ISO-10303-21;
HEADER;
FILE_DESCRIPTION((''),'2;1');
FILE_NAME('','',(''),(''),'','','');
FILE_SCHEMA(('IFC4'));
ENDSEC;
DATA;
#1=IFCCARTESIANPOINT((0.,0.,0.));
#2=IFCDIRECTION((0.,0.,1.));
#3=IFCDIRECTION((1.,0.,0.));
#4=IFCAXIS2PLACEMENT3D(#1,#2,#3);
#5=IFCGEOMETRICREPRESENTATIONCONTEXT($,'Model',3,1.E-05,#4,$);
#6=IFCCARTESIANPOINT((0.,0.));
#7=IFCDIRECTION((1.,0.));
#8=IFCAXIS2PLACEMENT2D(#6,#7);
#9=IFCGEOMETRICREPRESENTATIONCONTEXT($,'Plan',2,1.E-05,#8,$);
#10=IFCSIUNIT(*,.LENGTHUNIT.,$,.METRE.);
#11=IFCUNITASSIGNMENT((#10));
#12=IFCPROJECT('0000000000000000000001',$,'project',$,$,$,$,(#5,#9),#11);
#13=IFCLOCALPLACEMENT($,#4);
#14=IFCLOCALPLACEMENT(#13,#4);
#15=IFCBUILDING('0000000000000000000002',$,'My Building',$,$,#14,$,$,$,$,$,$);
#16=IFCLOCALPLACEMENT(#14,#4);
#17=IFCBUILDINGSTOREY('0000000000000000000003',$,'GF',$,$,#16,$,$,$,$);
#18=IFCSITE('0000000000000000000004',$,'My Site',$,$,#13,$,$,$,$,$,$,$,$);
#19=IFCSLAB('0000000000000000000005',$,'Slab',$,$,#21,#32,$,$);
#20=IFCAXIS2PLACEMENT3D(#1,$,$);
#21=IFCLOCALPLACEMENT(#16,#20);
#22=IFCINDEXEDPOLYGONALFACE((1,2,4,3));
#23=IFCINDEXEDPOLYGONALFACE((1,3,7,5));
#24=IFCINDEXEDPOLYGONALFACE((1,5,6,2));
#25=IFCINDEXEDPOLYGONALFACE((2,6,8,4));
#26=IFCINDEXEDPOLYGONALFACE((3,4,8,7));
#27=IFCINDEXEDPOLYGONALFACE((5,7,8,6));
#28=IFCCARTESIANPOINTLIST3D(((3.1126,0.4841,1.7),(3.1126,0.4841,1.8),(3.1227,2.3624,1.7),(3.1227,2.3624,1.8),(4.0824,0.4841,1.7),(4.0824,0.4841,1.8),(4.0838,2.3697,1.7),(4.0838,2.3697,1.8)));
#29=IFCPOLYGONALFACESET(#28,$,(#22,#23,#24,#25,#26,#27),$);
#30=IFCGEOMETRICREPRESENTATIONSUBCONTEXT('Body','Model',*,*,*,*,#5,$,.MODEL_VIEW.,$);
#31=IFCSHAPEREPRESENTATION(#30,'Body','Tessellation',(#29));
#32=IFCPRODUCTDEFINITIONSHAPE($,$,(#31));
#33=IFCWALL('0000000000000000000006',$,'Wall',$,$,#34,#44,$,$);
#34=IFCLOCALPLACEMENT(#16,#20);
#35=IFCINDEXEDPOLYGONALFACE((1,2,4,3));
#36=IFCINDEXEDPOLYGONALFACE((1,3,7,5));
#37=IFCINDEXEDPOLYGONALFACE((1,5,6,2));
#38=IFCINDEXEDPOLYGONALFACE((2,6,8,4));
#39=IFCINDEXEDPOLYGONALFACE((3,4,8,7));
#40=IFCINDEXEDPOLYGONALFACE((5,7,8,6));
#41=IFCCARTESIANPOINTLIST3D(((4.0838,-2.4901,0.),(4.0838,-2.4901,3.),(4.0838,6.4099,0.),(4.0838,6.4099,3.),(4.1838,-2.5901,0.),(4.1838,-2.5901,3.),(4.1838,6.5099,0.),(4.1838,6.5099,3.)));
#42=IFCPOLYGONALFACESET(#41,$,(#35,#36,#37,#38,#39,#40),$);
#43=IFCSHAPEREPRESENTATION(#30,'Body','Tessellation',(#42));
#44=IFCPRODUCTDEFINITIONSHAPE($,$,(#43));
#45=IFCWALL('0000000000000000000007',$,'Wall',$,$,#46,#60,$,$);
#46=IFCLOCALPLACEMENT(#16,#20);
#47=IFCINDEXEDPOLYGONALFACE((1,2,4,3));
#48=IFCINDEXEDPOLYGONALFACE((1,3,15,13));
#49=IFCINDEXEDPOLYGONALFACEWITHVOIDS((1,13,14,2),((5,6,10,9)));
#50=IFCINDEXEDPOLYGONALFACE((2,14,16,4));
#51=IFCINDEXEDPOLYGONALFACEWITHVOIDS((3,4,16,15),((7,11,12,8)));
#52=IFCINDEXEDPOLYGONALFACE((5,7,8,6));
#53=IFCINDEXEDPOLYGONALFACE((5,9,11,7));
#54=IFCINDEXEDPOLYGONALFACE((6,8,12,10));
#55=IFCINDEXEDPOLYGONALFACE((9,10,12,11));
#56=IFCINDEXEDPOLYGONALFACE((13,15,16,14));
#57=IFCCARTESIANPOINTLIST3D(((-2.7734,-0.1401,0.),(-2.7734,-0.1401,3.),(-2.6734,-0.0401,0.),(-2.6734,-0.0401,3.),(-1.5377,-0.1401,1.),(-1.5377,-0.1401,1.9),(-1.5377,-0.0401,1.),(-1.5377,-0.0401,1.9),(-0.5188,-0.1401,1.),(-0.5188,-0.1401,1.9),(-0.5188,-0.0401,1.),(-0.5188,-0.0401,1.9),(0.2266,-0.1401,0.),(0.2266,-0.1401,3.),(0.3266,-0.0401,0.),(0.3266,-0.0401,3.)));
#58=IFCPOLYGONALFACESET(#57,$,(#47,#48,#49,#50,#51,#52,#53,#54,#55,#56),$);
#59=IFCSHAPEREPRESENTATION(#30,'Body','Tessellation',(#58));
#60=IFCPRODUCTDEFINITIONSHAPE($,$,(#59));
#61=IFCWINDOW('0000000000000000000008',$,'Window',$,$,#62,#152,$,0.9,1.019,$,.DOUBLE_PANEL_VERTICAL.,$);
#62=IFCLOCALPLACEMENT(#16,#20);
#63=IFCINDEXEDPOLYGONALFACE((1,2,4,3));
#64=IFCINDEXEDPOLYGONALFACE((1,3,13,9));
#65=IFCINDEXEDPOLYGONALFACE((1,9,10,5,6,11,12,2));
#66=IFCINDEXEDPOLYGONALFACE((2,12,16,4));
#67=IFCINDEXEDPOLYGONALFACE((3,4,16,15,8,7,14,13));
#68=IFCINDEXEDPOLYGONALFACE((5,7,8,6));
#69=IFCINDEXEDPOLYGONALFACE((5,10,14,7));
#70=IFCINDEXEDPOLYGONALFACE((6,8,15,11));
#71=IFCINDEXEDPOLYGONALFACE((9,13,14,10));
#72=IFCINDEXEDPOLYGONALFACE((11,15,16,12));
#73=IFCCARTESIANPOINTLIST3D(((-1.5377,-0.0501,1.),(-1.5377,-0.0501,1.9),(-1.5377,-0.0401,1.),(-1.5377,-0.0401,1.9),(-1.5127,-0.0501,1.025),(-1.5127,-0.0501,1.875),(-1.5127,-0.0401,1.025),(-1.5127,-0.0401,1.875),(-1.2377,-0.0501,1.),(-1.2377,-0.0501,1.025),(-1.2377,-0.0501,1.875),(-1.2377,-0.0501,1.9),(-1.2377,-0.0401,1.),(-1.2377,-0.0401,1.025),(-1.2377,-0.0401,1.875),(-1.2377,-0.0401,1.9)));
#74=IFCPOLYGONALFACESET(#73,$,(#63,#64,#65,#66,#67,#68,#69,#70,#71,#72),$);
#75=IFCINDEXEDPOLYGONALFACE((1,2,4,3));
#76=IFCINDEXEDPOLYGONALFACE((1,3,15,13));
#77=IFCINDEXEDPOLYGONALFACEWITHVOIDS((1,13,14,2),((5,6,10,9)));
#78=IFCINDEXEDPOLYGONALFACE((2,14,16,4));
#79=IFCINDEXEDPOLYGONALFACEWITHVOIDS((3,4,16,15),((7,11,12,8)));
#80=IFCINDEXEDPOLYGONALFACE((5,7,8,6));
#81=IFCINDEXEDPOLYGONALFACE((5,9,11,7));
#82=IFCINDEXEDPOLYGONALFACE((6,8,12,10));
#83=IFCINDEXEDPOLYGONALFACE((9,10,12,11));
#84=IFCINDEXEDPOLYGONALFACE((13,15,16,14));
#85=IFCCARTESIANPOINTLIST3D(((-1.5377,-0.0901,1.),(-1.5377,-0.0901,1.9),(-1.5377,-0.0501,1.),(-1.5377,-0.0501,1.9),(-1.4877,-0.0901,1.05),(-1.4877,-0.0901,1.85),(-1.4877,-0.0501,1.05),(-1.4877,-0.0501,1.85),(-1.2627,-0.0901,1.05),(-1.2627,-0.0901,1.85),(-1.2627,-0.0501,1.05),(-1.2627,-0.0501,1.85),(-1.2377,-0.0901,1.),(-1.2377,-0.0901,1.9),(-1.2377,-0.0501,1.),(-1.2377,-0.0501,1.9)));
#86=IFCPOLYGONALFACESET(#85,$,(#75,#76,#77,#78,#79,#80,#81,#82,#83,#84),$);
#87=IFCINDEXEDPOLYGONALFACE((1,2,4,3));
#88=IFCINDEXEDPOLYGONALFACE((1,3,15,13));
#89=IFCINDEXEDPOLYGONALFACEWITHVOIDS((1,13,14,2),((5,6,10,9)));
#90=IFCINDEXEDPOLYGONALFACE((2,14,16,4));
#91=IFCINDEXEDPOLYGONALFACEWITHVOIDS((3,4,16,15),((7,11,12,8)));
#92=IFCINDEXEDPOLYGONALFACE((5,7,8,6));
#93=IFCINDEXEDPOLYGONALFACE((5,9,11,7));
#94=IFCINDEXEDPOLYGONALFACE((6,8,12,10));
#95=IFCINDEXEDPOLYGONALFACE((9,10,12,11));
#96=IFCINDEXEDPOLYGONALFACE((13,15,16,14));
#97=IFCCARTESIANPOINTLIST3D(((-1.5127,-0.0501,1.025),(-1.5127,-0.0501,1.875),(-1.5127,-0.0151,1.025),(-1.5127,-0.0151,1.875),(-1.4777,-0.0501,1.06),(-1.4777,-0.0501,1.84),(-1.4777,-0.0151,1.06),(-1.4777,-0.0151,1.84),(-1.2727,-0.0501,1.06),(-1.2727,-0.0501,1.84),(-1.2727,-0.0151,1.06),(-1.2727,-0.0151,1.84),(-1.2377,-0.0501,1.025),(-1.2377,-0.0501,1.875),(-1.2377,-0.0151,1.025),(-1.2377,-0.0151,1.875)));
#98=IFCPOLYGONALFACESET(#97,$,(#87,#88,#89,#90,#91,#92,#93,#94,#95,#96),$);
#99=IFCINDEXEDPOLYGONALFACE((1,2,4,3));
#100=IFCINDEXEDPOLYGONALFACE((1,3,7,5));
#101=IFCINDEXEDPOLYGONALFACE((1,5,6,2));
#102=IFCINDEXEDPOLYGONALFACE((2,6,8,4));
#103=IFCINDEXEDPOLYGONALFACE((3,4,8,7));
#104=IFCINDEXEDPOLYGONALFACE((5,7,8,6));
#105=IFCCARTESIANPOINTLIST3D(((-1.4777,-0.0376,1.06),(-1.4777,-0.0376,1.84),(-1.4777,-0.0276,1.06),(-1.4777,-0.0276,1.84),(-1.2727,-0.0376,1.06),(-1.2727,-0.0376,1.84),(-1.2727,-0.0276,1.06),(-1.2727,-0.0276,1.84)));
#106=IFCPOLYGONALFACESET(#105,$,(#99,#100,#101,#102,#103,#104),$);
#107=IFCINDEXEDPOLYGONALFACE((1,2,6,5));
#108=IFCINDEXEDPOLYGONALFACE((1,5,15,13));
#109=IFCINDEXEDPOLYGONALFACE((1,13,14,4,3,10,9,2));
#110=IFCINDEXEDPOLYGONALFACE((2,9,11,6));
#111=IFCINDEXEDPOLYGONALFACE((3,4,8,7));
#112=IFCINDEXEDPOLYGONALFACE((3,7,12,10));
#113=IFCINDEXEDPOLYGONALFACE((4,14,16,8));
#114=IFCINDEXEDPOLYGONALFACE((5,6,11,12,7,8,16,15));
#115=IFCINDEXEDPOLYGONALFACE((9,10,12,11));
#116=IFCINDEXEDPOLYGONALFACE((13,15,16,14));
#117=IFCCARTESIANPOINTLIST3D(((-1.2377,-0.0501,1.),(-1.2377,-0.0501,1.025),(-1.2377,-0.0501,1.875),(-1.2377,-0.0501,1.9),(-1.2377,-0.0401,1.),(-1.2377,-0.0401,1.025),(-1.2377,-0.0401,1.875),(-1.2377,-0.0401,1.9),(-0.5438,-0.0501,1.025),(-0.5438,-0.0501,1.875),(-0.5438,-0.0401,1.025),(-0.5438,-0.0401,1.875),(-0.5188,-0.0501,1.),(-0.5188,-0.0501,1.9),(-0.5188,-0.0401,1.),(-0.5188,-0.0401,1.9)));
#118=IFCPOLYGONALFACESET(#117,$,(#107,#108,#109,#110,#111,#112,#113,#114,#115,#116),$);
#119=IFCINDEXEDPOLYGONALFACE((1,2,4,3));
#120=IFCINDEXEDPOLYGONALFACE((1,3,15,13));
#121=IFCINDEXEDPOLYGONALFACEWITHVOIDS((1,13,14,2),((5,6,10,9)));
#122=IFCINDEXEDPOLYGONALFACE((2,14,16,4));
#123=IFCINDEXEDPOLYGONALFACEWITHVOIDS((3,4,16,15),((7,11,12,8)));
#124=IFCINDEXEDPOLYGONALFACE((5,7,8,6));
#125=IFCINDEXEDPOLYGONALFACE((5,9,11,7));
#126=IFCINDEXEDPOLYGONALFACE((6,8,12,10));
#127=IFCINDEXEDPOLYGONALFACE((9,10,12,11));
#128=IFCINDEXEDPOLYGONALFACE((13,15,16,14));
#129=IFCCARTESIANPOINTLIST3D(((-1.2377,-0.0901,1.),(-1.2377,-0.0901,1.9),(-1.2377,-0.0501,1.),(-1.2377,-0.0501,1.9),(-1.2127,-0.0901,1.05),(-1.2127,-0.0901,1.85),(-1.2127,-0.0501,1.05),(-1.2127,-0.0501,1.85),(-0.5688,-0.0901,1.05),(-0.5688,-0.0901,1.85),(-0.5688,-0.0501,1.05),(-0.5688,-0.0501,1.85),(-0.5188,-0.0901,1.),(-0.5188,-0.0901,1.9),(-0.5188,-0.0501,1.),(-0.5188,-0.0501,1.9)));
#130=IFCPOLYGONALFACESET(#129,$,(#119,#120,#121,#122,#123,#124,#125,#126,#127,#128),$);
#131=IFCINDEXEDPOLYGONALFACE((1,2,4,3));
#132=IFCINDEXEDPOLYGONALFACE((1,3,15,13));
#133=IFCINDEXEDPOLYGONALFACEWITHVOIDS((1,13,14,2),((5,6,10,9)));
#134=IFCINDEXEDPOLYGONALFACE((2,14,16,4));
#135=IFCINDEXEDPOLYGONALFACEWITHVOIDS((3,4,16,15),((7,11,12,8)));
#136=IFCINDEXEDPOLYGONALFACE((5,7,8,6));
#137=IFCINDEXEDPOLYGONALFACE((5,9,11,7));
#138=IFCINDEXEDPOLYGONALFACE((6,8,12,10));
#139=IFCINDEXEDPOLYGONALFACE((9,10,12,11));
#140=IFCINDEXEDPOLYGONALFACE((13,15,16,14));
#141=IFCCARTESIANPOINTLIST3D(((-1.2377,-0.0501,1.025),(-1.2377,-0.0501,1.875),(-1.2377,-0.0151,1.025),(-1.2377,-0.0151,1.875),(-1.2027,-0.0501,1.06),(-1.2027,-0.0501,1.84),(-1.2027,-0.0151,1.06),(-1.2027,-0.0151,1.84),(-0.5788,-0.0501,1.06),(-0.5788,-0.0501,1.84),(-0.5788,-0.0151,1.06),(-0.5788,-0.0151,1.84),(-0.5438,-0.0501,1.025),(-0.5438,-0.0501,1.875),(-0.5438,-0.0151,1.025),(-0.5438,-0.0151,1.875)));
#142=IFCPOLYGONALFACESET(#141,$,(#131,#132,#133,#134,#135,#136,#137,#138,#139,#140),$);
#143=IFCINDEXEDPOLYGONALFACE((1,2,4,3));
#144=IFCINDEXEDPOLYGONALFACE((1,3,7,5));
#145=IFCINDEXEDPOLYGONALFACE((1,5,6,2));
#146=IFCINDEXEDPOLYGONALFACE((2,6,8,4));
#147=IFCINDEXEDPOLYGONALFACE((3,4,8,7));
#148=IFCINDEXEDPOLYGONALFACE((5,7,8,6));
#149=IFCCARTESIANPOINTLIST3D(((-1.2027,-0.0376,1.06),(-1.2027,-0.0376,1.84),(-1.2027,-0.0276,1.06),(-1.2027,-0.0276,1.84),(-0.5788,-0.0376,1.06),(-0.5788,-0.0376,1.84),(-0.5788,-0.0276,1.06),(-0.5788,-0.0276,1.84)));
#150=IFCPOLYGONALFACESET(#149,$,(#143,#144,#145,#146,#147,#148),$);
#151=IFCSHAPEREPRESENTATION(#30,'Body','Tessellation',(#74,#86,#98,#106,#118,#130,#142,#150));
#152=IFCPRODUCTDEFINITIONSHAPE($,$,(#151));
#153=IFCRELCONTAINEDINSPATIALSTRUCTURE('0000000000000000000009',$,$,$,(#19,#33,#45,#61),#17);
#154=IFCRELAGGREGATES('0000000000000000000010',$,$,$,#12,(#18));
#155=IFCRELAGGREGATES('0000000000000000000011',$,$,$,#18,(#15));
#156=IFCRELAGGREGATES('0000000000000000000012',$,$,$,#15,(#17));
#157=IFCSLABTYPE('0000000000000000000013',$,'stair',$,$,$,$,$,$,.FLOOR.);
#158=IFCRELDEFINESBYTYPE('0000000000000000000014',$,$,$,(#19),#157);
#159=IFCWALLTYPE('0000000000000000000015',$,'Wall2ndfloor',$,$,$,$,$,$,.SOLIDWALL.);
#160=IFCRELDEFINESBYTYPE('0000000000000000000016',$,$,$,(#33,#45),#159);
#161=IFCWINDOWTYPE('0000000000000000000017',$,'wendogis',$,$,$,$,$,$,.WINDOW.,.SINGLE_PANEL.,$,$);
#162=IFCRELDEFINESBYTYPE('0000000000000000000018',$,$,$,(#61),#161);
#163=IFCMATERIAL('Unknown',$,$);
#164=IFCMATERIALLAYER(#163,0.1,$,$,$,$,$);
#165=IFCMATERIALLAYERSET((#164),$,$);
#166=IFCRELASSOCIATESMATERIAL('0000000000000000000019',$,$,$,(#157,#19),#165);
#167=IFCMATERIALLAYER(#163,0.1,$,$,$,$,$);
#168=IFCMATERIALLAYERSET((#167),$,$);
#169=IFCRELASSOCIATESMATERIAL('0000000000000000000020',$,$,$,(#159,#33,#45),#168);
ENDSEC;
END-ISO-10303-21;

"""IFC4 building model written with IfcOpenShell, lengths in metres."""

from ifc_helpers import new_model, entity, si_unit, frame, origin_with_axes, origin_2d_with_axis, place, context, subcontext, project, spatial, line, indexed_curve, outline, extrude, shape, source, transform, mapped, material, layer, layer_set, layer_usage, type_object, type_shapes, element, fill, save


model = new_model("IFC4")

# Units and contexts
model_context = context("Model", 3, precision=1e-05, world=origin_with_axes())
plan_context = context("Plan", 2, precision=1e-05, world=origin_2d_with_axis())
body_context_1 = subcontext(model_context, "Body", "Model", "MODEL_VIEW")
body_context_2 = subcontext(plan_context, "Body", "Plan", "PLAN_VIEW")
ifc_project = project(units=[si_unit("LENGTHUNIT", "METRE")], contexts=[model_context, plan_context])

# Site, building, storey
site_placement = place(None, origin_with_axes())
site = spatial("IfcSite", under=ifc_project, at=site_placement, Name="My Site")
building_placement = place(site_placement, origin_with_axes())
building = spatial("IfcBuilding", under=site, at=building_placement, Name="My Building")
storey_placement = place(building_placement, origin_with_axes())
storey = spatial("IfcBuildingStorey", under=building, at=storey_placement, Name="GF")

# Shared definitions
ifc_material = material(Name="Unknown")

# Slab
ifc_layer_1 = layer(ifc_material, 0.1)
ifc_layer_set_1 = layer_set([ifc_layer_1])
ifc_layer_usage_1 = layer_usage(ifc_layer_set_1, "AXIS3", "POSITIVE", -0.1)
slab_type_1 = type_object("IfcSlabType", Name="stair", PredefinedType="FLOOR", material=ifc_layer_set_1)
slab_1_placement = place(storey_placement, frame((4.0824, 0.4841, 1.8), z_axis=(0.0, 0.0, 1.0), x_axis=(1.0, 0.0, 0.0)))
element("IfcSlab", 1, at=slab_1_placement, inside=storey, type_object=slab_type_1, material=ifc_layer_usage_1, Name="Slab", context=body_context_1, shape_type="SweptSolid", body=[
    extrude(outline(indexed_curve([(0.0, 0.0), (-0.9698, 0.0), (-0.9597, 1.8784), (0.0014, 1.8856), (0.0, 0.0)])), frame((0.0, 0.0, -0.1), z_axis=(0.0, 0.0, 1.0), x_axis=(1.0, 0.0, 0.0)), (0.0, 0.0, 1.0), 0.1),
])

# Shared definitions
ifc_layer_2 = layer(ifc_material, 0.1)
ifc_layer_set_2 = layer_set([ifc_layer_2])
wall_type_1 = type_object("IfcWallType", Name="Wall2ndfloor", PredefinedType="SOLIDWALL", material=ifc_layer_set_2)

# Wall
ifc_layer_usage_2 = layer_usage(ifc_layer_set_2, "AXIS2", "POSITIVE", 0.0)
wall_1_placement = place(storey_placement, frame((4.1838, -2.5901, 0.0), z_axis=(0.0, 0.0, 1.0), x_axis=(0.0, 1.0, 0.0)))
element("IfcWall", 2, at=wall_1_placement, inside=storey, type_object=wall_type_1, material=ifc_layer_usage_2, Name="Wall", context=body_context_1, shape_type="SweptSolid", body=[
    extrude(outline(indexed_curve([(0.0, 0.0), (0.1, 0.1), (9.0, 0.1), (9.1, 0.0)], segments=[line(1, 2, 3, 4, 1)])), origin_with_axes(), (0.0, 0.0, 1.0), 3.0),
])

# Wall, opening, window
ifc_layer_usage_3 = layer_usage(ifc_layer_set_2, "AXIS2", "POSITIVE", 0.0)
wall_2_placement = place(storey_placement, frame((-2.7734, -0.1401, 0.0), z_axis=(0.0, 0.0, 1.0), x_axis=(1.0, 0.0, 0.0)))
wall_2 = element("IfcWall", 3, at=wall_2_placement, inside=storey, type_object=wall_type_1, material=ifc_layer_usage_3, Name="Wall", context=body_context_1, shape_type="SweptSolid", body=[
    extrude(outline(indexed_curve([(0.0, 0.0), (0.1, 0.1), (3.1, 0.1), (3.0, 0.0)], segments=[line(1, 2, 3, 4, 1)])), origin_with_axes(), (0.0, 0.0, 1.0), 3.0),
])
shared_shape_1 = source(origin_with_axes(), body_context_1, "Body", "SweptSolid", [
    extrude(outline(indexed_curve([(0.0, 0.0), (1.019, 0.0), (1.019, 0.9), (0.0, 0.9)], segments=[line(1, 2, 3, 4, 1)])), frame((0.0, -0.6, 0.0), z_axis=(0.0, -1.0, 0.0), x_axis=(1.0, 0.0, 0.0)), (0.0, 0.0, -1.0), 1.2),
])
opening_1_placement = place(wall_2_placement, frame((1.2356, 0.0, 1.0), z_axis=(0.0, 0.0, 1.0), x_axis=(1.0, 0.0, 0.0)))
opening_1 = element("IfcOpeningElement", 4, at=opening_1_placement, cuts=wall_2, PredefinedType="OPENING", context=body_context_1, shape_type="MappedRepresentation", body=[
    mapped(shared_shape_1, transform((0.0, 0.0, 0.0), x_axis=(1.0, 0.0, 0.0), y_axis=(0.0, 1.0, 0.0), z_axis=(0.0, 0.0, 1.0), scale=1.0)),
])
window_type_1 = type_object("IfcWindowType", Name="wendogis", PartitioningType="SINGLE_PANEL", PredefinedType="WINDOW")
shared_shape_2 = source(origin_with_axes(), body_context_1, "Body", "SweptSolid", [
    extrude(outline(indexed_curve([(0.3, 0.0), (0.0, 0.0), (0.0, 0.9), (0.3, 0.9), (0.3, 0.875), (0.025, 0.875), (0.025, 0.025), (0.3, 0.025)], segments=[line(1, 2, 3, 4, 5, 6, 7, 8, 1)])), frame((0.0, 0.09, 0.0), z_axis=(0.0, -1.0, 0.0), x_axis=(1.0, 0.0, 0.0)), (0.0, 0.0, -1.0), 0.01),
    extrude(outline(indexed_curve([(0.0, 0.0), (0.3, 0.0), (0.3, 0.9), (0.0, 0.9)], segments=[line(1, 2, 3, 4, 1)]), holes=[indexed_curve([(0.05, 0.05), (0.275, 0.05), (0.275, 0.85), (0.05, 0.85)], segments=[line(1, 2, 3, 4, 1)])]), frame((0.0, 0.05, 0.0), z_axis=(0.0, -1.0, 0.0), x_axis=(1.0, 0.0, 0.0)), (0.0, 0.0, -1.0), 0.04),
    extrude(outline(indexed_curve([(0.0, 0.0), (0.275, 0.0), (0.275, 0.85), (0.0, 0.85)], segments=[line(1, 2, 3, 4, 1)]), holes=[indexed_curve([(0.035, 0.035), (0.24, 0.035), (0.24, 0.815), (0.035, 0.815)], segments=[line(1, 2, 3, 4, 1)])]), frame((0.025, 0.09, 0.025), z_axis=(0.0, -1.0, 0.0), x_axis=(1.0, 0.0, 0.0)), (0.0, 0.0, -1.0), 0.035),
    extrude(outline(indexed_curve([(0.035, 0.035), (0.24, 0.035), (0.24, 0.815), (0.035, 0.815)], segments=[line(1, 2, 3, 4, 1)])), frame((0.025, 0.1025, 0.025), z_axis=(0.0, -1.0, 0.0), x_axis=(1.0, 0.0, 0.0)), (0.0, 0.0, -1.0), 0.01),
    extrude(outline(indexed_curve([(0.0, 0.9), (0.719, 0.9), (0.719, 0.0), (0.0, 0.0), (0.0, 0.025), (0.694, 0.025), (0.694, 0.875), (0.0, 0.875)], segments=[line(1, 2, 3, 4, 5, 6, 7, 8, 1)])), frame((0.3, 0.09, 0.0), z_axis=(0.0, -1.0, 0.0), x_axis=(1.0, 0.0, 0.0)), (0.0, 0.0, -1.0), 0.01),
    extrude(outline(indexed_curve([(0.0, 0.0), (0.719, 0.0), (0.719, 0.9), (0.0, 0.9)], segments=[line(1, 2, 3, 4, 1)]), holes=[indexed_curve([(0.025, 0.05), (0.669, 0.05), (0.669, 0.85), (0.025, 0.85)], segments=[line(1, 2, 3, 4, 1)])]), frame((0.3, 0.05, 0.0), z_axis=(0.0, -1.0, 0.0), x_axis=(1.0, 0.0, 0.0)), (0.0, 0.0, -1.0), 0.04),
    extrude(outline(indexed_curve([(0.0, 0.0), (0.694, 0.0), (0.694, 0.85), (0.0, 0.85)], segments=[line(1, 2, 3, 4, 1)]), holes=[indexed_curve([(0.035, 0.035), (0.659, 0.035), (0.659, 0.815), (0.035, 0.815)], segments=[line(1, 2, 3, 4, 1)])]), frame((0.3, 0.09, 0.025), z_axis=(0.0, -1.0, 0.0), x_axis=(1.0, 0.0, 0.0)), (0.0, 0.0, -1.0), 0.035),
    extrude(outline(indexed_curve([(0.035, 0.035), (0.659, 0.035), (0.659, 0.815), (0.035, 0.815)], segments=[line(1, 2, 3, 4, 1)])), frame((0.3, 0.1025, 0.025), z_axis=(0.0, -1.0, 0.0), x_axis=(1.0, 0.0, 0.0)), (0.0, 0.0, -1.0), 0.01),
])
shared_shape_3 = source(origin_with_axes(), body_context_2, "Body", "Curve2D", [
    entity("IfcIndexedPolyCurve", entity("IfcCartesianPointList2D", [[0.05, 0.05], [0.275, 0.05]])),
    entity("IfcIndexedPolyCurve", entity("IfcCartesianPointList2D", [[0.0, 0.1], [0.025, 0.1], [0.025, 0.09], [0.05, 0.09], [0.05, 0.05], [0.0, 0.05]]), [entity("IfcLineIndex", [1, 2, 3, 4, 5, 6, 1])]),
    entity("IfcIndexedPolyCurve", entity("IfcCartesianPointList2D", [[0.3, 0.1], [0.3, 0.1], [0.3, 0.09], [0.275, 0.09], [0.275, 0.05], [0.3, 0.05]])),
    entity("IfcIndexedPolyCurve", entity("IfcCartesianPointList2D", [[0.025, 0.09], [0.06, 0.09], [0.06, 0.125], [0.025, 0.125]]), [entity("IfcLineIndex", [1, 2, 3, 4, 1])]),
    entity("IfcIndexedPolyCurve", entity("IfcCartesianPointList2D", [[0.3, 0.09], [0.265, 0.09], [0.265, 0.125], [0.3, 0.125]]), [entity("IfcLineIndex", [1, 2, 3, 4, 1])]),
    entity("IfcIndexedPolyCurve", entity("IfcCartesianPointList2D", [[0.06, 0.09], [0.265, 0.09]])),
    entity("IfcIndexedPolyCurve", entity("IfcCartesianPointList2D", [[0.06, 0.125], [0.265, 0.125]])),
    entity("IfcIndexedPolyCurve", entity("IfcCartesianPointList2D", [[0.06, 0.1075], [0.265, 0.1075]])),
    entity("IfcIndexedPolyCurve", entity("IfcCartesianPointList2D", [[0.325, 0.05], [0.969, 0.05]])),
    entity("IfcIndexedPolyCurve", entity("IfcCartesianPointList2D", [[0.3, 0.1], [0.3, 0.1], [0.3, 0.09], [0.325, 0.09], [0.325, 0.05], [0.3, 0.05]])),
    entity("IfcIndexedPolyCurve", entity("IfcCartesianPointList2D", [[1.019, 0.1], [0.994, 0.1], [0.994, 0.09], [0.969, 0.09], [0.969, 0.05], [1.019, 0.05]]), [entity("IfcLineIndex", [1, 2, 3, 4, 5, 6, 1])]),
    entity("IfcIndexedPolyCurve", entity("IfcCartesianPointList2D", [[0.3, 0.09], [0.335, 0.09], [0.335, 0.125], [0.3, 0.125]]), [entity("IfcLineIndex", [1, 2, 3, 4, 1])]),
    entity("IfcIndexedPolyCurve", entity("IfcCartesianPointList2D", [[0.994, 0.09], [0.959, 0.09], [0.959, 0.125], [0.994, 0.125]]), [entity("IfcLineIndex", [1, 2, 3, 4, 1])]),
    entity("IfcIndexedPolyCurve", entity("IfcCartesianPointList2D", [[0.335, 0.09], [0.959, 0.09]])),
    entity("IfcIndexedPolyCurve", entity("IfcCartesianPointList2D", [[0.335, 0.125], [0.959, 0.125]])),
    entity("IfcIndexedPolyCurve", entity("IfcCartesianPointList2D", [[0.335, 0.1075], [0.959, 0.1075]])),
])
type_shapes(window_type_1, [shared_shape_2, shared_shape_3])
window_1_placement = place(opening_1_placement, frame((0.0, 0.0, 0.0), z_axis=(0.0, 0.0, 1.0), x_axis=(1.0, 0.0, 0.0)))
window_1 = element("IfcWindow", 5, at=window_1_placement, inside=storey, type_object=window_type_1, Name="Window", OverallHeight=0.9, OverallWidth=1.019, PartitioningType="DOUBLE_PANEL_VERTICAL", shapes=[
    shape(body_context_1, "Body", "MappedRepresentation", [mapped(shared_shape_2, transform((0.0, 0.0, 0.0), x_axis=(1.0, 0.0, 0.0), y_axis=(0.0, 1.0, 0.0), z_axis=(0.0, 0.0, 1.0), scale=1.0))]),
    shape(body_context_2, "Body", "MappedRepresentation", [mapped(shared_shape_3, transform((0.0, 0.0, 0.0), x_axis=(1.0, 0.0, 0.0), y_axis=(0.0, 1.0, 0.0), z_axis=(0.0, 0.0, 1.0), scale=1.0))]),
])
fill(opening_1, window_1)

save(model, "model.ifc")
